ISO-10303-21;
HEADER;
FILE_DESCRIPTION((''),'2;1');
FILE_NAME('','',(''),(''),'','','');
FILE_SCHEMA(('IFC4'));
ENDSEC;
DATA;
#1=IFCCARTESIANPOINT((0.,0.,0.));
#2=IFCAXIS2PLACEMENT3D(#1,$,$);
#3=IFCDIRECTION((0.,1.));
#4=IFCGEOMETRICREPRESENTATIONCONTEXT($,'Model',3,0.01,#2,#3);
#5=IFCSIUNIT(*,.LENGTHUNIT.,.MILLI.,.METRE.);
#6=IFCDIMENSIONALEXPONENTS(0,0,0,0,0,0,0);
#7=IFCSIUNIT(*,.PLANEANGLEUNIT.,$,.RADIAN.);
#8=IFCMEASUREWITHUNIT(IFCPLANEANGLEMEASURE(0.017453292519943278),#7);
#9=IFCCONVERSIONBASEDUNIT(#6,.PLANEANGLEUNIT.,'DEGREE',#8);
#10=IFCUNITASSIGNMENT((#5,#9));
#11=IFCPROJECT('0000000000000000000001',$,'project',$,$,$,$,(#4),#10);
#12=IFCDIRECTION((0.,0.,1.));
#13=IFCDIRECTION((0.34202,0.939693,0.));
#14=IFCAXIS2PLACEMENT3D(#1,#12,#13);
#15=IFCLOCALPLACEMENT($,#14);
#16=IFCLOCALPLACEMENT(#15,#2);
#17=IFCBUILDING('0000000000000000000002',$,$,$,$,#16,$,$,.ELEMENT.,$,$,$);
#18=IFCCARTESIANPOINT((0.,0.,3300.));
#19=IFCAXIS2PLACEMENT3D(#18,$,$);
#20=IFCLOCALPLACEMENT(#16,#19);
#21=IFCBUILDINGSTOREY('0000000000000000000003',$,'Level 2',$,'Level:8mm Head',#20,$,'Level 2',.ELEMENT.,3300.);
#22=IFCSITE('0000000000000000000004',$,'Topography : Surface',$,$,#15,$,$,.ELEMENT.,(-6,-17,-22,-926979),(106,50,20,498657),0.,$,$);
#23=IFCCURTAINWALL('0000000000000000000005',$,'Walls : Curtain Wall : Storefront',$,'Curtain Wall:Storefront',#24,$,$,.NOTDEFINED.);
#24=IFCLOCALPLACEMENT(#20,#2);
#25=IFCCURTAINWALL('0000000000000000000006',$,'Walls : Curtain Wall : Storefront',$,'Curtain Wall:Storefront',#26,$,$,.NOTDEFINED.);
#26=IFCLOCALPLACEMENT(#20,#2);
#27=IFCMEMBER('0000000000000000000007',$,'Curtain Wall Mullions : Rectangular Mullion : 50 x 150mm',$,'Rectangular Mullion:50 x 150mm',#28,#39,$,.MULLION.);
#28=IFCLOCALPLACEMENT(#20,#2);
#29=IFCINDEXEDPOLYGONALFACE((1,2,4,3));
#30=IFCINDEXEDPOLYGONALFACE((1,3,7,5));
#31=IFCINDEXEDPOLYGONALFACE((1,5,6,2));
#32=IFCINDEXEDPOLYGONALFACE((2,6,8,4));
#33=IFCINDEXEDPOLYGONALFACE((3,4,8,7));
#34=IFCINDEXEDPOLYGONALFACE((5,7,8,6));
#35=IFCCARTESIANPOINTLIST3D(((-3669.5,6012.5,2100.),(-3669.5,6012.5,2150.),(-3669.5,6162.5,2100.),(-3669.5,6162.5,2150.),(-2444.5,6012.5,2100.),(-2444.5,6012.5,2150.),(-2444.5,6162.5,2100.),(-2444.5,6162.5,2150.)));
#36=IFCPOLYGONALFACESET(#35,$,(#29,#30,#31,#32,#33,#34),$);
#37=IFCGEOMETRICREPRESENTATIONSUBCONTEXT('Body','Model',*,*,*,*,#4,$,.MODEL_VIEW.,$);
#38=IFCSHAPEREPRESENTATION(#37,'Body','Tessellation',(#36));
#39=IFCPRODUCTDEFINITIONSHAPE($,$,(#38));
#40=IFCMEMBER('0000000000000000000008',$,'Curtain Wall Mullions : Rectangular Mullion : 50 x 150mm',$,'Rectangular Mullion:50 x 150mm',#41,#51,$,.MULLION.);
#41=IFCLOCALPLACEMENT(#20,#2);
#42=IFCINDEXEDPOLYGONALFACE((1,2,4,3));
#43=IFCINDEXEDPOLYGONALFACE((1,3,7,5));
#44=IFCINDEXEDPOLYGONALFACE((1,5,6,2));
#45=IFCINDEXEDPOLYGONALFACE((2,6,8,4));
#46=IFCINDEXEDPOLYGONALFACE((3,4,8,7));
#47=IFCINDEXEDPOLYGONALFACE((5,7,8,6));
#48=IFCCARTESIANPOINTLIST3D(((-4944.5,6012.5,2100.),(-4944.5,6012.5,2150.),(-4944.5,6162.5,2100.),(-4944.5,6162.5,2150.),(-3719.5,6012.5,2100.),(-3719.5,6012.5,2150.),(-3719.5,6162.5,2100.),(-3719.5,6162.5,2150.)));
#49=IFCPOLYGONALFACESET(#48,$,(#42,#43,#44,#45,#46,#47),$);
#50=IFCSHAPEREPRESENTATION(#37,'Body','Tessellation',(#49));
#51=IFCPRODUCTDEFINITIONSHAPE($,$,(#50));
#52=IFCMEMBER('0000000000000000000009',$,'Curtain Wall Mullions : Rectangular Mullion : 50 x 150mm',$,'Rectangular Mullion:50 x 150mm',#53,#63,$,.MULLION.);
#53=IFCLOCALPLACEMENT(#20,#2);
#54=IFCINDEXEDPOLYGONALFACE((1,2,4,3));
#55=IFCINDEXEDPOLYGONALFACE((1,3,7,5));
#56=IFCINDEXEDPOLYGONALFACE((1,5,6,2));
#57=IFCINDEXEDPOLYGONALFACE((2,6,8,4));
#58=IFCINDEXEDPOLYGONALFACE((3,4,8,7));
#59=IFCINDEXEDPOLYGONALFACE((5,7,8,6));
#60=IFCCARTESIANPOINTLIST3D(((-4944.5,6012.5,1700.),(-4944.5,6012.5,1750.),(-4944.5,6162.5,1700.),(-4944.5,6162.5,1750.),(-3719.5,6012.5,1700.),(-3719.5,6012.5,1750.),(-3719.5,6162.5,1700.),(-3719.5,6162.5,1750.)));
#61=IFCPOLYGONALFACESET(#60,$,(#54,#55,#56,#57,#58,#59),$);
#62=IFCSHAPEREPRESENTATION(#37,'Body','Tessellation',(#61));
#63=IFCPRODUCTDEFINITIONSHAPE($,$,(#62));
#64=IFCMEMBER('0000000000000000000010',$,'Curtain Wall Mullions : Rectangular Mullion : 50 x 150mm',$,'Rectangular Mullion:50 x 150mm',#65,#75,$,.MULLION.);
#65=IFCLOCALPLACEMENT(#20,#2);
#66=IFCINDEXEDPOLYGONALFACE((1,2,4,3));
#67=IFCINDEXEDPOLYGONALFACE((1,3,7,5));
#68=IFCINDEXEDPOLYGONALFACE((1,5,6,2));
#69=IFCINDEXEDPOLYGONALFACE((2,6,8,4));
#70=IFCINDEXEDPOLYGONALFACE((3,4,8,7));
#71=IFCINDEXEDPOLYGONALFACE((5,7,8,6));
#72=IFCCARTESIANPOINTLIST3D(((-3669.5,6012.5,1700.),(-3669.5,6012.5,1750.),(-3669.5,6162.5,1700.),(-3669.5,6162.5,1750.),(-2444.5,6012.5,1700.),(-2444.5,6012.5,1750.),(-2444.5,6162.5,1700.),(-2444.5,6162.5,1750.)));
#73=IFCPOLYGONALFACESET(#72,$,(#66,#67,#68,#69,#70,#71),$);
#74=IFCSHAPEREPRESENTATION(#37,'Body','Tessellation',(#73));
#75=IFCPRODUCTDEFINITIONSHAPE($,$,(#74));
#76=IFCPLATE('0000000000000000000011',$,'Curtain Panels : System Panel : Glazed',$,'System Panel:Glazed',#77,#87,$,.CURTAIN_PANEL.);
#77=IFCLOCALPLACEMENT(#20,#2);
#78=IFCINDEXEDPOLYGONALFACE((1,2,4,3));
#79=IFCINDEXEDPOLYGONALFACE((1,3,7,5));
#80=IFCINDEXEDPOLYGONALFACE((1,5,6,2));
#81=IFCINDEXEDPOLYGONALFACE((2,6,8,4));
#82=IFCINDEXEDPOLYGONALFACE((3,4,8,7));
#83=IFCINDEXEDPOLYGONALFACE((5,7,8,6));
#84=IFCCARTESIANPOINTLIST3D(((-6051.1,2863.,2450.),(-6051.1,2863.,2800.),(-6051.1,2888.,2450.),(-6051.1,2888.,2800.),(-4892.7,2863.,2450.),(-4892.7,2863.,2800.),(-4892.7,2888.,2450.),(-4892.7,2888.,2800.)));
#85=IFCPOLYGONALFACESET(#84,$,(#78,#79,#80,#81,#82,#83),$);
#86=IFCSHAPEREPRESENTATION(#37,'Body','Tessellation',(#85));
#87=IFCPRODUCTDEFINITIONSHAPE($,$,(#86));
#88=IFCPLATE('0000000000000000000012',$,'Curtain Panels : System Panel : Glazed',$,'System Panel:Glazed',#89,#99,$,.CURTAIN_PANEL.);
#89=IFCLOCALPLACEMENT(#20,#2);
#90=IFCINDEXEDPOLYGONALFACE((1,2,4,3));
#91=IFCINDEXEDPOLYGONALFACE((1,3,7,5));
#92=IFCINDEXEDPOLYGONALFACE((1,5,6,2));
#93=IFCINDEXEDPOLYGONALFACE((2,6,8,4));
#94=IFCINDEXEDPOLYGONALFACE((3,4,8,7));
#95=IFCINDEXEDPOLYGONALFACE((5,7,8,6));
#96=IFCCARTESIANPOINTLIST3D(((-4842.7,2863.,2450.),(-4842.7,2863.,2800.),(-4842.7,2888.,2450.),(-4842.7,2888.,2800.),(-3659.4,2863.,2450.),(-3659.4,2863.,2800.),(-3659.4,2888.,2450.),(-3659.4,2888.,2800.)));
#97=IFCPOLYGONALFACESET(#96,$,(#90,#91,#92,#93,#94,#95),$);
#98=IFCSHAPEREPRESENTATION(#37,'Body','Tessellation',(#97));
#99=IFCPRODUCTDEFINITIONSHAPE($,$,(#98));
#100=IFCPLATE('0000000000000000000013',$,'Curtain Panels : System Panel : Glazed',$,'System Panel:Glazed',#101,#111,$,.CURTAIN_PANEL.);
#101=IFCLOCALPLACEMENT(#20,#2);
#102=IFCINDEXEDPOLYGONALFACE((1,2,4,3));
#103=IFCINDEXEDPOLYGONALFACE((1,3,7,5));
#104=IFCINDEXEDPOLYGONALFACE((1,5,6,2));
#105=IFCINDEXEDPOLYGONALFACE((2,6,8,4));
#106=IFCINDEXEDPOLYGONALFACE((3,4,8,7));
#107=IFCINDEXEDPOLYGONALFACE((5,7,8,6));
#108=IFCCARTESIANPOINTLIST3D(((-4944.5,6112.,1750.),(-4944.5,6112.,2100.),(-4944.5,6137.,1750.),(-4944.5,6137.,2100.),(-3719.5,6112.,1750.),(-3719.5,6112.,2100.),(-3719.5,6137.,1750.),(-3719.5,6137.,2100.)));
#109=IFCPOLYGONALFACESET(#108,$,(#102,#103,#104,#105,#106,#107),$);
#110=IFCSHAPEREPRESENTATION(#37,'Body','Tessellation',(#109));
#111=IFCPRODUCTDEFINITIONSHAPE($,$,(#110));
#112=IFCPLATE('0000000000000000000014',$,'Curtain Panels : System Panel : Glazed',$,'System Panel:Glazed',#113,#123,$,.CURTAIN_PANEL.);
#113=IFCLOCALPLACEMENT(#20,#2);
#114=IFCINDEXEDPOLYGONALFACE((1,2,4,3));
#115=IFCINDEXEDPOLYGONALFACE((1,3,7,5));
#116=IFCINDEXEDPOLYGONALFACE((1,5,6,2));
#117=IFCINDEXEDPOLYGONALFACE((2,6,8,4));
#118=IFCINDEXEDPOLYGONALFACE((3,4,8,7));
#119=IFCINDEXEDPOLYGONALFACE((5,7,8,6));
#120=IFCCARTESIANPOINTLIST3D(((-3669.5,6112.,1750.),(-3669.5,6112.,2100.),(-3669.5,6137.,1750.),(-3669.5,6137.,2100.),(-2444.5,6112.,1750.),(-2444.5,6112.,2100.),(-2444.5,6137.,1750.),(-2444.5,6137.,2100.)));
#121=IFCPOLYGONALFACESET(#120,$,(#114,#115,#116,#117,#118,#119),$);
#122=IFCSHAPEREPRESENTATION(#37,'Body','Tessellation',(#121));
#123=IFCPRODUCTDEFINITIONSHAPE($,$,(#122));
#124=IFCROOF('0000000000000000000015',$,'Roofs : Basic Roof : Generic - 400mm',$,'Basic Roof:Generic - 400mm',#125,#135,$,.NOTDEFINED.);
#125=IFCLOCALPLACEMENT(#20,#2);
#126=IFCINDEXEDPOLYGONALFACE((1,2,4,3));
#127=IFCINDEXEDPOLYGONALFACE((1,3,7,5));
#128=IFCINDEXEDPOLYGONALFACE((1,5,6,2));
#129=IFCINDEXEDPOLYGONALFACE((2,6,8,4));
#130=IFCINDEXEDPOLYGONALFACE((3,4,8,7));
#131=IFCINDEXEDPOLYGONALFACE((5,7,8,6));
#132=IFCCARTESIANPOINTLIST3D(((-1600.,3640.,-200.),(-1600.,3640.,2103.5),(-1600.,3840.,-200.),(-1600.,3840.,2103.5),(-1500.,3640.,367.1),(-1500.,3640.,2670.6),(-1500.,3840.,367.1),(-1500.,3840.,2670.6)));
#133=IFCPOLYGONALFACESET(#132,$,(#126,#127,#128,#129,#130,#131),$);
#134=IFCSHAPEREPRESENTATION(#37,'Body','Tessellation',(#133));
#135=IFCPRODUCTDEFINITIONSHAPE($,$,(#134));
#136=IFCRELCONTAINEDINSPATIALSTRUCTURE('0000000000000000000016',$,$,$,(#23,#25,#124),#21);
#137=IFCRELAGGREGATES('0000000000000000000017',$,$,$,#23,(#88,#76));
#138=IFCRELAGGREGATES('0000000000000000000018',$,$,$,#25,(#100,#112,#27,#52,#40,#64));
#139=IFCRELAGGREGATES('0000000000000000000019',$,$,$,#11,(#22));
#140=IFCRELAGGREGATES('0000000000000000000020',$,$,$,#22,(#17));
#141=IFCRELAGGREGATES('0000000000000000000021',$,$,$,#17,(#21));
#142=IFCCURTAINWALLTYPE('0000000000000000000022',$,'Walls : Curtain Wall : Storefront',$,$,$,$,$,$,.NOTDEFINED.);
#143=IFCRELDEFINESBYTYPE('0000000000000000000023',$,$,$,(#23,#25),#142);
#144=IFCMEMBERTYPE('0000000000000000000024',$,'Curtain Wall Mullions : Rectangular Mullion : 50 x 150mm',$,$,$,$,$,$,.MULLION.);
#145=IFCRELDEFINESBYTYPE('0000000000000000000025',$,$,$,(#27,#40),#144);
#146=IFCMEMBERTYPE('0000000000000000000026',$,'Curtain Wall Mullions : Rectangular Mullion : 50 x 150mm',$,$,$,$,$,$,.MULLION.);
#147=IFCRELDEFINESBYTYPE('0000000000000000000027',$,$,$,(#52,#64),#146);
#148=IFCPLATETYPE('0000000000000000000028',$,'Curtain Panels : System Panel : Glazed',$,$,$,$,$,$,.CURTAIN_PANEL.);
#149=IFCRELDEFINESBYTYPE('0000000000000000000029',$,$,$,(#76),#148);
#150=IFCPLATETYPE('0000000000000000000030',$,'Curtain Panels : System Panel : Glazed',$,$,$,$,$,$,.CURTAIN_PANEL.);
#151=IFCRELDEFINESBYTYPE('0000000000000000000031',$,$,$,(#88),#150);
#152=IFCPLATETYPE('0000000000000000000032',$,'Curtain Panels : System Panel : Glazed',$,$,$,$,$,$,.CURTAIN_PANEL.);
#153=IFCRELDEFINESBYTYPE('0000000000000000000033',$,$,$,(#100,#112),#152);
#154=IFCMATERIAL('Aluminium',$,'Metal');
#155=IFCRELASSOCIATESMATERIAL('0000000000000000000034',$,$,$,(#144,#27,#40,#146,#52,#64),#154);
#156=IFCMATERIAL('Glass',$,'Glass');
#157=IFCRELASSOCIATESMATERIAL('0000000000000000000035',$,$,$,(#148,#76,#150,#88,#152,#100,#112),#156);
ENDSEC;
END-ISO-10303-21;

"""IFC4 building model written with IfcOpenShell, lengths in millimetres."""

from ifc_helpers import new_model, entity, si_unit, converted_unit, direction, frame, origin, place, context, subcontext, project, spatial, indexed_curve, outline, extrude, source, transform, mapped, material, type_object, type_shapes, element, aggregate, save


model = new_model("IFC4")

# Units and contexts
model_context = context("Model", 3, precision=0.01, world=origin(), true_north=direction((0.0, 1.0)))
body_context = subcontext(model_context, "Body", "Model", "MODEL_VIEW")
ifc_project = project(units=[si_unit("LENGTHUNIT", "METRE", prefix="MILLI"), converted_unit("PLANEANGLEUNIT", "DEGREE", entity("IfcPlaneAngleMeasure", 0.017453292519943278), si_unit("PLANEANGLEUNIT", "RADIAN"), dimensions=[0, 0, 0, 0, 0, 0, 0])], contexts=[model_context])

# Site, building, storey
site_placement = place(None, frame((0.0, 0.0, 0.0), z_axis=(0.0, 0.0, 1.0), x_axis=(0.34202, 0.939693, 0.0)))
site = spatial("IfcSite", under=ifc_project, at=site_placement, Name="Topography : Surface", CompositionType="ELEMENT", RefLatitude=(-6, -17, -22, -926979), RefLongitude=(106, 50, 20, 498657), RefElevation=0.0)
building_placement = place(site_placement, origin())
building = spatial("IfcBuilding", under=site, at=building_placement, CompositionType="ELEMENT")
storey_placement = place(building_placement, frame((0.0, 0.0, 3300.0)))
storey = spatial("IfcBuildingStorey", under=building, at=storey_placement, Name="Level 2", ObjectType="Level:8mm Head", LongName="Level 2", CompositionType="ELEMENT", Elevation=3300.0)

# Curtain walls
curtain_wall_type = type_object("IfcCurtainWallType", Name="Walls : Curtain Wall : Storefront", PredefinedType="NOTDEFINED")
curtain_wall_1_placement = place(storey_placement, frame((0.0, 0.0, -3300.0)))
curtain_wall_1 = element("IfcCurtainWall", 1, at=curtain_wall_1_placement, inside=storey, type_object=curtain_wall_type, Name="Walls : Curtain Wall : Storefront", ObjectType="Curtain Wall:Storefront", PredefinedType="NOTDEFINED")
ifc_material_1 = material(Name="Aluminium", Category="Metal")
curtain_wall_2_placement = place(storey_placement, frame((0.0, 0.0, -3300.0)))
curtain_wall_2 = element("IfcCurtainWall", 2, at=curtain_wall_2_placement, inside=storey, type_object=curtain_wall_type, Name="Walls : Curtain Wall : Storefront", ObjectType="Curtain Wall:Storefront", PredefinedType="NOTDEFINED")

# Members
member_type_1 = type_object("IfcMemberType", Name="Curtain Wall Mullions : Rectangular Mullion : 50 x 150mm", PredefinedType="MULLION", material=ifc_material_1)
shared_shape_1 = source(origin(), body_context, "Body", "SweptSolid", [
    extrude(outline(indexed_curve([(-25.0, -75.0), (25.0, -75.0), (25.0, 75.0), (-25.0, 75.0), (-25.0, -75.0)], self_intersect=False)), frame((-25.0, 0.0, -1225.0), z_axis=(0.0, 0.0, 1.0), x_axis=(-1.0, 0.0, 0.0)), (0.0, 0.0, 1.0), 1225.0),
])
type_shapes(member_type_1, [shared_shape_1])
member_1_placement = place(curtain_wall_2_placement, frame((-2444.5, 6087.5, 5450.0), z_axis=(1.0, 0.0, 0.0), x_axis=(0.0, 0.0, 1.0)))
member_1 = element("IfcMember", 3, at=member_1_placement, type_object=member_type_1, material=ifc_material_1, Name="Curtain Wall Mullions : Rectangular Mullion : 50 x 150mm", ObjectType="Rectangular Mullion:50 x 150mm", PredefinedType="MULLION", context=body_context, shape_type="MappedRepresentation", body=[
    mapped(shared_shape_1, transform((0.0, 0.0, 0.0), scale=1.0)),
])
member_2_placement = place(curtain_wall_2_placement, frame((-3719.5, 6087.5, 5450.0), z_axis=(1.0, 0.0, 0.0), x_axis=(0.0, 0.0, 1.0)))
member_2 = element("IfcMember", 4, at=member_2_placement, type_object=member_type_1, material=ifc_material_1, Name="Curtain Wall Mullions : Rectangular Mullion : 50 x 150mm", ObjectType="Rectangular Mullion:50 x 150mm", PredefinedType="MULLION", context=body_context, shape_type="MappedRepresentation", body=[
    mapped(shared_shape_1, transform((0.0, 0.0, 0.0), scale=1.0)),
])
member_type_2 = type_object("IfcMemberType", Name="Curtain Wall Mullions : Rectangular Mullion : 50 x 150mm", PredefinedType="MULLION", material=ifc_material_1)
shared_shape_2 = source(origin(), body_context, "Body", "SweptSolid", [
    extrude(outline(indexed_curve([(-25.0, -75.0), (25.0, -75.0), (25.0, 75.0), (-25.0, 75.0), (-25.0, -75.0)], self_intersect=False)), frame((-25.0, 0.0, -1225.0), z_axis=(0.0, 0.0, 1.0), x_axis=(-1.0, 0.0, 0.0)), (0.0, 0.0, 1.0), 1225.0),
])
type_shapes(member_type_2, [shared_shape_2])
member_3_placement = place(curtain_wall_2_placement, frame((-4944.5, 6087.5, 5000.0), z_axis=(-1.0, 0.0, 0.0), x_axis=(0.0, 0.0, -1.0)))
member_3 = element("IfcMember", 5, at=member_3_placement, type_object=member_type_2, material=ifc_material_1, Name="Curtain Wall Mullions : Rectangular Mullion : 50 x 150mm", ObjectType="Rectangular Mullion:50 x 150mm", PredefinedType="MULLION", context=body_context, shape_type="MappedRepresentation", body=[
    mapped(shared_shape_2, transform((0.0, 0.0, 0.0), scale=1.0)),
])
member_4_placement = place(curtain_wall_2_placement, frame((-3669.5, 6087.5, 5000.0), z_axis=(-1.0, 0.0, 0.0), x_axis=(0.0, 0.0, -1.0)))
member_4 = element("IfcMember", 6, at=member_4_placement, type_object=member_type_2, material=ifc_material_1, Name="Curtain Wall Mullions : Rectangular Mullion : 50 x 150mm", ObjectType="Rectangular Mullion:50 x 150mm", PredefinedType="MULLION", context=body_context, shape_type="MappedRepresentation", body=[
    mapped(shared_shape_2, transform((0.0, 0.0, 0.0), scale=1.0)),
])

# Plates
ifc_material_2 = material(Name="Glass", Category="Glass")
plate_type_1 = type_object("IfcPlateType", Name="Curtain Panels : System Panel : Glazed", PredefinedType="CURTAIN_PANEL", material=ifc_material_2)
shared_shape_3 = source(origin(), body_context, "Body", "SweptSolid", [
    extrude(outline(indexed_curve([(-12.5, -579.2), (12.5, -579.2), (12.5, 579.2), (-12.5, 579.2), (-12.5, -579.2)], self_intersect=False)), frame((579.2, 12.5, 0.0), z_axis=(0.0, 0.0, 1.0), x_axis=(0.0, 1.0, 0.0)), (0.0, 0.0, 1.0), 350.0),
])
type_shapes(plate_type_1, [shared_shape_3])
plate_1_placement = place(curtain_wall_1_placement, frame((-4892.7, 2888.0, 5750.0), z_axis=(0.0, 0.0, 1.0), x_axis=(-1.0, 0.0, 0.0)))
plate_1 = element("IfcPlate", 7, at=plate_1_placement, type_object=plate_type_1, material=ifc_material_2, Name="Curtain Panels : System Panel : Glazed", ObjectType="System Panel:Glazed", PredefinedType="CURTAIN_PANEL", context=body_context, shape_type="MappedRepresentation", body=[
    mapped(shared_shape_3, transform((0.0, 0.0, 0.0), scale=1.0)),
])
plate_type_2 = type_object("IfcPlateType", Name="Curtain Panels : System Panel : Glazed", PredefinedType="CURTAIN_PANEL", material=ifc_material_2)
shared_shape_4 = source(origin(), body_context, "Body", "SweptSolid", [
    extrude(outline(indexed_curve([(-12.5, -591.7), (12.5, -591.7), (12.5, 591.7), (-12.5, 591.7), (-12.5, -591.7)], self_intersect=False)), frame((591.7, 12.5, 0.0), z_axis=(0.0, 0.0, 1.0), x_axis=(0.0, 1.0, 0.0)), (0.0, 0.0, 1.0), 350.0),
])
type_shapes(plate_type_2, [shared_shape_4])
plate_2_placement = place(curtain_wall_1_placement, frame((-3659.4, 2888.0, 5750.0), z_axis=(0.0, 0.0, 1.0), x_axis=(-1.0, 0.0, 0.0)))
plate_2 = element("IfcPlate", 8, at=plate_2_placement, type_object=plate_type_2, material=ifc_material_2, Name="Curtain Panels : System Panel : Glazed", ObjectType="System Panel:Glazed", PredefinedType="CURTAIN_PANEL", context=body_context, shape_type="MappedRepresentation", body=[
    mapped(shared_shape_4, transform((0.0, 0.0, 0.0), scale=1.0)),
])
aggregate(curtain_wall_1, [plate_2, plate_1])
plate_type_3 = type_object("IfcPlateType", Name="Curtain Panels : System Panel : Glazed", PredefinedType="CURTAIN_PANEL", material=ifc_material_2)
shared_shape_5 = source(origin(), body_context, "Body", "SweptSolid", [
    extrude(outline(indexed_curve([(-12.5, -612.5), (12.5, -612.5), (12.5, 612.5), (-12.5, 612.5), (-12.5, -612.5)], self_intersect=False)), frame((612.5, 12.5, 0.0), z_axis=(0.0, 0.0, 1.0), x_axis=(0.0, 1.0, 0.0)), (0.0, 0.0, 1.0), 350.0),
])
type_shapes(plate_type_3, [shared_shape_5])
plate_3_placement = place(curtain_wall_2_placement, frame((-4944.5, 6112.0, 5050.0)))
plate_3 = element("IfcPlate", 9, at=plate_3_placement, type_object=plate_type_3, material=ifc_material_2, Name="Curtain Panels : System Panel : Glazed", ObjectType="System Panel:Glazed", PredefinedType="CURTAIN_PANEL", context=body_context, shape_type="MappedRepresentation", body=[
    mapped(shared_shape_5, transform((0.0, 0.0, 0.0), scale=1.0)),
])
plate_4_placement = place(curtain_wall_2_placement, frame((-3669.5, 6112.0, 5050.0)))
plate_4 = element("IfcPlate", 10, at=plate_4_placement, type_object=plate_type_3, material=ifc_material_2, Name="Curtain Panels : System Panel : Glazed", ObjectType="System Panel:Glazed", PredefinedType="CURTAIN_PANEL", context=body_context, shape_type="MappedRepresentation", body=[
    mapped(shared_shape_5, transform((0.0, 0.0, 0.0), scale=1.0)),
])
aggregate(curtain_wall_2, [plate_3, plate_4, member_1, member_3, member_2, member_4])

# Roof
roof_placement = place(storey_placement, frame((-1600.0, 3640.0, -200.0)))
element("IfcRoof", 11, at=roof_placement, inside=storey, Name="Roofs : Basic Roof : Generic - 400mm", ObjectType="Basic Roof:Generic - 400mm", PredefinedType="NOTDEFINED", context=body_context, shape_type="SweptSolid", body=[
    extrude(outline(indexed_curve([(-287.9, 100.0), (-287.9, -100.0), (287.9, -100.0), (287.9, 100.0), (-287.9, 100.0)], self_intersect=False)), frame((50.0, 100.0, 283.6), z_axis=(-0.984808, 0.0, 0.173648), x_axis=(0.173648, 0.0, 0.984808)), (0.984808, 0.0, 0.173648), 2303.5),
])

save(model, "model.ifc")
